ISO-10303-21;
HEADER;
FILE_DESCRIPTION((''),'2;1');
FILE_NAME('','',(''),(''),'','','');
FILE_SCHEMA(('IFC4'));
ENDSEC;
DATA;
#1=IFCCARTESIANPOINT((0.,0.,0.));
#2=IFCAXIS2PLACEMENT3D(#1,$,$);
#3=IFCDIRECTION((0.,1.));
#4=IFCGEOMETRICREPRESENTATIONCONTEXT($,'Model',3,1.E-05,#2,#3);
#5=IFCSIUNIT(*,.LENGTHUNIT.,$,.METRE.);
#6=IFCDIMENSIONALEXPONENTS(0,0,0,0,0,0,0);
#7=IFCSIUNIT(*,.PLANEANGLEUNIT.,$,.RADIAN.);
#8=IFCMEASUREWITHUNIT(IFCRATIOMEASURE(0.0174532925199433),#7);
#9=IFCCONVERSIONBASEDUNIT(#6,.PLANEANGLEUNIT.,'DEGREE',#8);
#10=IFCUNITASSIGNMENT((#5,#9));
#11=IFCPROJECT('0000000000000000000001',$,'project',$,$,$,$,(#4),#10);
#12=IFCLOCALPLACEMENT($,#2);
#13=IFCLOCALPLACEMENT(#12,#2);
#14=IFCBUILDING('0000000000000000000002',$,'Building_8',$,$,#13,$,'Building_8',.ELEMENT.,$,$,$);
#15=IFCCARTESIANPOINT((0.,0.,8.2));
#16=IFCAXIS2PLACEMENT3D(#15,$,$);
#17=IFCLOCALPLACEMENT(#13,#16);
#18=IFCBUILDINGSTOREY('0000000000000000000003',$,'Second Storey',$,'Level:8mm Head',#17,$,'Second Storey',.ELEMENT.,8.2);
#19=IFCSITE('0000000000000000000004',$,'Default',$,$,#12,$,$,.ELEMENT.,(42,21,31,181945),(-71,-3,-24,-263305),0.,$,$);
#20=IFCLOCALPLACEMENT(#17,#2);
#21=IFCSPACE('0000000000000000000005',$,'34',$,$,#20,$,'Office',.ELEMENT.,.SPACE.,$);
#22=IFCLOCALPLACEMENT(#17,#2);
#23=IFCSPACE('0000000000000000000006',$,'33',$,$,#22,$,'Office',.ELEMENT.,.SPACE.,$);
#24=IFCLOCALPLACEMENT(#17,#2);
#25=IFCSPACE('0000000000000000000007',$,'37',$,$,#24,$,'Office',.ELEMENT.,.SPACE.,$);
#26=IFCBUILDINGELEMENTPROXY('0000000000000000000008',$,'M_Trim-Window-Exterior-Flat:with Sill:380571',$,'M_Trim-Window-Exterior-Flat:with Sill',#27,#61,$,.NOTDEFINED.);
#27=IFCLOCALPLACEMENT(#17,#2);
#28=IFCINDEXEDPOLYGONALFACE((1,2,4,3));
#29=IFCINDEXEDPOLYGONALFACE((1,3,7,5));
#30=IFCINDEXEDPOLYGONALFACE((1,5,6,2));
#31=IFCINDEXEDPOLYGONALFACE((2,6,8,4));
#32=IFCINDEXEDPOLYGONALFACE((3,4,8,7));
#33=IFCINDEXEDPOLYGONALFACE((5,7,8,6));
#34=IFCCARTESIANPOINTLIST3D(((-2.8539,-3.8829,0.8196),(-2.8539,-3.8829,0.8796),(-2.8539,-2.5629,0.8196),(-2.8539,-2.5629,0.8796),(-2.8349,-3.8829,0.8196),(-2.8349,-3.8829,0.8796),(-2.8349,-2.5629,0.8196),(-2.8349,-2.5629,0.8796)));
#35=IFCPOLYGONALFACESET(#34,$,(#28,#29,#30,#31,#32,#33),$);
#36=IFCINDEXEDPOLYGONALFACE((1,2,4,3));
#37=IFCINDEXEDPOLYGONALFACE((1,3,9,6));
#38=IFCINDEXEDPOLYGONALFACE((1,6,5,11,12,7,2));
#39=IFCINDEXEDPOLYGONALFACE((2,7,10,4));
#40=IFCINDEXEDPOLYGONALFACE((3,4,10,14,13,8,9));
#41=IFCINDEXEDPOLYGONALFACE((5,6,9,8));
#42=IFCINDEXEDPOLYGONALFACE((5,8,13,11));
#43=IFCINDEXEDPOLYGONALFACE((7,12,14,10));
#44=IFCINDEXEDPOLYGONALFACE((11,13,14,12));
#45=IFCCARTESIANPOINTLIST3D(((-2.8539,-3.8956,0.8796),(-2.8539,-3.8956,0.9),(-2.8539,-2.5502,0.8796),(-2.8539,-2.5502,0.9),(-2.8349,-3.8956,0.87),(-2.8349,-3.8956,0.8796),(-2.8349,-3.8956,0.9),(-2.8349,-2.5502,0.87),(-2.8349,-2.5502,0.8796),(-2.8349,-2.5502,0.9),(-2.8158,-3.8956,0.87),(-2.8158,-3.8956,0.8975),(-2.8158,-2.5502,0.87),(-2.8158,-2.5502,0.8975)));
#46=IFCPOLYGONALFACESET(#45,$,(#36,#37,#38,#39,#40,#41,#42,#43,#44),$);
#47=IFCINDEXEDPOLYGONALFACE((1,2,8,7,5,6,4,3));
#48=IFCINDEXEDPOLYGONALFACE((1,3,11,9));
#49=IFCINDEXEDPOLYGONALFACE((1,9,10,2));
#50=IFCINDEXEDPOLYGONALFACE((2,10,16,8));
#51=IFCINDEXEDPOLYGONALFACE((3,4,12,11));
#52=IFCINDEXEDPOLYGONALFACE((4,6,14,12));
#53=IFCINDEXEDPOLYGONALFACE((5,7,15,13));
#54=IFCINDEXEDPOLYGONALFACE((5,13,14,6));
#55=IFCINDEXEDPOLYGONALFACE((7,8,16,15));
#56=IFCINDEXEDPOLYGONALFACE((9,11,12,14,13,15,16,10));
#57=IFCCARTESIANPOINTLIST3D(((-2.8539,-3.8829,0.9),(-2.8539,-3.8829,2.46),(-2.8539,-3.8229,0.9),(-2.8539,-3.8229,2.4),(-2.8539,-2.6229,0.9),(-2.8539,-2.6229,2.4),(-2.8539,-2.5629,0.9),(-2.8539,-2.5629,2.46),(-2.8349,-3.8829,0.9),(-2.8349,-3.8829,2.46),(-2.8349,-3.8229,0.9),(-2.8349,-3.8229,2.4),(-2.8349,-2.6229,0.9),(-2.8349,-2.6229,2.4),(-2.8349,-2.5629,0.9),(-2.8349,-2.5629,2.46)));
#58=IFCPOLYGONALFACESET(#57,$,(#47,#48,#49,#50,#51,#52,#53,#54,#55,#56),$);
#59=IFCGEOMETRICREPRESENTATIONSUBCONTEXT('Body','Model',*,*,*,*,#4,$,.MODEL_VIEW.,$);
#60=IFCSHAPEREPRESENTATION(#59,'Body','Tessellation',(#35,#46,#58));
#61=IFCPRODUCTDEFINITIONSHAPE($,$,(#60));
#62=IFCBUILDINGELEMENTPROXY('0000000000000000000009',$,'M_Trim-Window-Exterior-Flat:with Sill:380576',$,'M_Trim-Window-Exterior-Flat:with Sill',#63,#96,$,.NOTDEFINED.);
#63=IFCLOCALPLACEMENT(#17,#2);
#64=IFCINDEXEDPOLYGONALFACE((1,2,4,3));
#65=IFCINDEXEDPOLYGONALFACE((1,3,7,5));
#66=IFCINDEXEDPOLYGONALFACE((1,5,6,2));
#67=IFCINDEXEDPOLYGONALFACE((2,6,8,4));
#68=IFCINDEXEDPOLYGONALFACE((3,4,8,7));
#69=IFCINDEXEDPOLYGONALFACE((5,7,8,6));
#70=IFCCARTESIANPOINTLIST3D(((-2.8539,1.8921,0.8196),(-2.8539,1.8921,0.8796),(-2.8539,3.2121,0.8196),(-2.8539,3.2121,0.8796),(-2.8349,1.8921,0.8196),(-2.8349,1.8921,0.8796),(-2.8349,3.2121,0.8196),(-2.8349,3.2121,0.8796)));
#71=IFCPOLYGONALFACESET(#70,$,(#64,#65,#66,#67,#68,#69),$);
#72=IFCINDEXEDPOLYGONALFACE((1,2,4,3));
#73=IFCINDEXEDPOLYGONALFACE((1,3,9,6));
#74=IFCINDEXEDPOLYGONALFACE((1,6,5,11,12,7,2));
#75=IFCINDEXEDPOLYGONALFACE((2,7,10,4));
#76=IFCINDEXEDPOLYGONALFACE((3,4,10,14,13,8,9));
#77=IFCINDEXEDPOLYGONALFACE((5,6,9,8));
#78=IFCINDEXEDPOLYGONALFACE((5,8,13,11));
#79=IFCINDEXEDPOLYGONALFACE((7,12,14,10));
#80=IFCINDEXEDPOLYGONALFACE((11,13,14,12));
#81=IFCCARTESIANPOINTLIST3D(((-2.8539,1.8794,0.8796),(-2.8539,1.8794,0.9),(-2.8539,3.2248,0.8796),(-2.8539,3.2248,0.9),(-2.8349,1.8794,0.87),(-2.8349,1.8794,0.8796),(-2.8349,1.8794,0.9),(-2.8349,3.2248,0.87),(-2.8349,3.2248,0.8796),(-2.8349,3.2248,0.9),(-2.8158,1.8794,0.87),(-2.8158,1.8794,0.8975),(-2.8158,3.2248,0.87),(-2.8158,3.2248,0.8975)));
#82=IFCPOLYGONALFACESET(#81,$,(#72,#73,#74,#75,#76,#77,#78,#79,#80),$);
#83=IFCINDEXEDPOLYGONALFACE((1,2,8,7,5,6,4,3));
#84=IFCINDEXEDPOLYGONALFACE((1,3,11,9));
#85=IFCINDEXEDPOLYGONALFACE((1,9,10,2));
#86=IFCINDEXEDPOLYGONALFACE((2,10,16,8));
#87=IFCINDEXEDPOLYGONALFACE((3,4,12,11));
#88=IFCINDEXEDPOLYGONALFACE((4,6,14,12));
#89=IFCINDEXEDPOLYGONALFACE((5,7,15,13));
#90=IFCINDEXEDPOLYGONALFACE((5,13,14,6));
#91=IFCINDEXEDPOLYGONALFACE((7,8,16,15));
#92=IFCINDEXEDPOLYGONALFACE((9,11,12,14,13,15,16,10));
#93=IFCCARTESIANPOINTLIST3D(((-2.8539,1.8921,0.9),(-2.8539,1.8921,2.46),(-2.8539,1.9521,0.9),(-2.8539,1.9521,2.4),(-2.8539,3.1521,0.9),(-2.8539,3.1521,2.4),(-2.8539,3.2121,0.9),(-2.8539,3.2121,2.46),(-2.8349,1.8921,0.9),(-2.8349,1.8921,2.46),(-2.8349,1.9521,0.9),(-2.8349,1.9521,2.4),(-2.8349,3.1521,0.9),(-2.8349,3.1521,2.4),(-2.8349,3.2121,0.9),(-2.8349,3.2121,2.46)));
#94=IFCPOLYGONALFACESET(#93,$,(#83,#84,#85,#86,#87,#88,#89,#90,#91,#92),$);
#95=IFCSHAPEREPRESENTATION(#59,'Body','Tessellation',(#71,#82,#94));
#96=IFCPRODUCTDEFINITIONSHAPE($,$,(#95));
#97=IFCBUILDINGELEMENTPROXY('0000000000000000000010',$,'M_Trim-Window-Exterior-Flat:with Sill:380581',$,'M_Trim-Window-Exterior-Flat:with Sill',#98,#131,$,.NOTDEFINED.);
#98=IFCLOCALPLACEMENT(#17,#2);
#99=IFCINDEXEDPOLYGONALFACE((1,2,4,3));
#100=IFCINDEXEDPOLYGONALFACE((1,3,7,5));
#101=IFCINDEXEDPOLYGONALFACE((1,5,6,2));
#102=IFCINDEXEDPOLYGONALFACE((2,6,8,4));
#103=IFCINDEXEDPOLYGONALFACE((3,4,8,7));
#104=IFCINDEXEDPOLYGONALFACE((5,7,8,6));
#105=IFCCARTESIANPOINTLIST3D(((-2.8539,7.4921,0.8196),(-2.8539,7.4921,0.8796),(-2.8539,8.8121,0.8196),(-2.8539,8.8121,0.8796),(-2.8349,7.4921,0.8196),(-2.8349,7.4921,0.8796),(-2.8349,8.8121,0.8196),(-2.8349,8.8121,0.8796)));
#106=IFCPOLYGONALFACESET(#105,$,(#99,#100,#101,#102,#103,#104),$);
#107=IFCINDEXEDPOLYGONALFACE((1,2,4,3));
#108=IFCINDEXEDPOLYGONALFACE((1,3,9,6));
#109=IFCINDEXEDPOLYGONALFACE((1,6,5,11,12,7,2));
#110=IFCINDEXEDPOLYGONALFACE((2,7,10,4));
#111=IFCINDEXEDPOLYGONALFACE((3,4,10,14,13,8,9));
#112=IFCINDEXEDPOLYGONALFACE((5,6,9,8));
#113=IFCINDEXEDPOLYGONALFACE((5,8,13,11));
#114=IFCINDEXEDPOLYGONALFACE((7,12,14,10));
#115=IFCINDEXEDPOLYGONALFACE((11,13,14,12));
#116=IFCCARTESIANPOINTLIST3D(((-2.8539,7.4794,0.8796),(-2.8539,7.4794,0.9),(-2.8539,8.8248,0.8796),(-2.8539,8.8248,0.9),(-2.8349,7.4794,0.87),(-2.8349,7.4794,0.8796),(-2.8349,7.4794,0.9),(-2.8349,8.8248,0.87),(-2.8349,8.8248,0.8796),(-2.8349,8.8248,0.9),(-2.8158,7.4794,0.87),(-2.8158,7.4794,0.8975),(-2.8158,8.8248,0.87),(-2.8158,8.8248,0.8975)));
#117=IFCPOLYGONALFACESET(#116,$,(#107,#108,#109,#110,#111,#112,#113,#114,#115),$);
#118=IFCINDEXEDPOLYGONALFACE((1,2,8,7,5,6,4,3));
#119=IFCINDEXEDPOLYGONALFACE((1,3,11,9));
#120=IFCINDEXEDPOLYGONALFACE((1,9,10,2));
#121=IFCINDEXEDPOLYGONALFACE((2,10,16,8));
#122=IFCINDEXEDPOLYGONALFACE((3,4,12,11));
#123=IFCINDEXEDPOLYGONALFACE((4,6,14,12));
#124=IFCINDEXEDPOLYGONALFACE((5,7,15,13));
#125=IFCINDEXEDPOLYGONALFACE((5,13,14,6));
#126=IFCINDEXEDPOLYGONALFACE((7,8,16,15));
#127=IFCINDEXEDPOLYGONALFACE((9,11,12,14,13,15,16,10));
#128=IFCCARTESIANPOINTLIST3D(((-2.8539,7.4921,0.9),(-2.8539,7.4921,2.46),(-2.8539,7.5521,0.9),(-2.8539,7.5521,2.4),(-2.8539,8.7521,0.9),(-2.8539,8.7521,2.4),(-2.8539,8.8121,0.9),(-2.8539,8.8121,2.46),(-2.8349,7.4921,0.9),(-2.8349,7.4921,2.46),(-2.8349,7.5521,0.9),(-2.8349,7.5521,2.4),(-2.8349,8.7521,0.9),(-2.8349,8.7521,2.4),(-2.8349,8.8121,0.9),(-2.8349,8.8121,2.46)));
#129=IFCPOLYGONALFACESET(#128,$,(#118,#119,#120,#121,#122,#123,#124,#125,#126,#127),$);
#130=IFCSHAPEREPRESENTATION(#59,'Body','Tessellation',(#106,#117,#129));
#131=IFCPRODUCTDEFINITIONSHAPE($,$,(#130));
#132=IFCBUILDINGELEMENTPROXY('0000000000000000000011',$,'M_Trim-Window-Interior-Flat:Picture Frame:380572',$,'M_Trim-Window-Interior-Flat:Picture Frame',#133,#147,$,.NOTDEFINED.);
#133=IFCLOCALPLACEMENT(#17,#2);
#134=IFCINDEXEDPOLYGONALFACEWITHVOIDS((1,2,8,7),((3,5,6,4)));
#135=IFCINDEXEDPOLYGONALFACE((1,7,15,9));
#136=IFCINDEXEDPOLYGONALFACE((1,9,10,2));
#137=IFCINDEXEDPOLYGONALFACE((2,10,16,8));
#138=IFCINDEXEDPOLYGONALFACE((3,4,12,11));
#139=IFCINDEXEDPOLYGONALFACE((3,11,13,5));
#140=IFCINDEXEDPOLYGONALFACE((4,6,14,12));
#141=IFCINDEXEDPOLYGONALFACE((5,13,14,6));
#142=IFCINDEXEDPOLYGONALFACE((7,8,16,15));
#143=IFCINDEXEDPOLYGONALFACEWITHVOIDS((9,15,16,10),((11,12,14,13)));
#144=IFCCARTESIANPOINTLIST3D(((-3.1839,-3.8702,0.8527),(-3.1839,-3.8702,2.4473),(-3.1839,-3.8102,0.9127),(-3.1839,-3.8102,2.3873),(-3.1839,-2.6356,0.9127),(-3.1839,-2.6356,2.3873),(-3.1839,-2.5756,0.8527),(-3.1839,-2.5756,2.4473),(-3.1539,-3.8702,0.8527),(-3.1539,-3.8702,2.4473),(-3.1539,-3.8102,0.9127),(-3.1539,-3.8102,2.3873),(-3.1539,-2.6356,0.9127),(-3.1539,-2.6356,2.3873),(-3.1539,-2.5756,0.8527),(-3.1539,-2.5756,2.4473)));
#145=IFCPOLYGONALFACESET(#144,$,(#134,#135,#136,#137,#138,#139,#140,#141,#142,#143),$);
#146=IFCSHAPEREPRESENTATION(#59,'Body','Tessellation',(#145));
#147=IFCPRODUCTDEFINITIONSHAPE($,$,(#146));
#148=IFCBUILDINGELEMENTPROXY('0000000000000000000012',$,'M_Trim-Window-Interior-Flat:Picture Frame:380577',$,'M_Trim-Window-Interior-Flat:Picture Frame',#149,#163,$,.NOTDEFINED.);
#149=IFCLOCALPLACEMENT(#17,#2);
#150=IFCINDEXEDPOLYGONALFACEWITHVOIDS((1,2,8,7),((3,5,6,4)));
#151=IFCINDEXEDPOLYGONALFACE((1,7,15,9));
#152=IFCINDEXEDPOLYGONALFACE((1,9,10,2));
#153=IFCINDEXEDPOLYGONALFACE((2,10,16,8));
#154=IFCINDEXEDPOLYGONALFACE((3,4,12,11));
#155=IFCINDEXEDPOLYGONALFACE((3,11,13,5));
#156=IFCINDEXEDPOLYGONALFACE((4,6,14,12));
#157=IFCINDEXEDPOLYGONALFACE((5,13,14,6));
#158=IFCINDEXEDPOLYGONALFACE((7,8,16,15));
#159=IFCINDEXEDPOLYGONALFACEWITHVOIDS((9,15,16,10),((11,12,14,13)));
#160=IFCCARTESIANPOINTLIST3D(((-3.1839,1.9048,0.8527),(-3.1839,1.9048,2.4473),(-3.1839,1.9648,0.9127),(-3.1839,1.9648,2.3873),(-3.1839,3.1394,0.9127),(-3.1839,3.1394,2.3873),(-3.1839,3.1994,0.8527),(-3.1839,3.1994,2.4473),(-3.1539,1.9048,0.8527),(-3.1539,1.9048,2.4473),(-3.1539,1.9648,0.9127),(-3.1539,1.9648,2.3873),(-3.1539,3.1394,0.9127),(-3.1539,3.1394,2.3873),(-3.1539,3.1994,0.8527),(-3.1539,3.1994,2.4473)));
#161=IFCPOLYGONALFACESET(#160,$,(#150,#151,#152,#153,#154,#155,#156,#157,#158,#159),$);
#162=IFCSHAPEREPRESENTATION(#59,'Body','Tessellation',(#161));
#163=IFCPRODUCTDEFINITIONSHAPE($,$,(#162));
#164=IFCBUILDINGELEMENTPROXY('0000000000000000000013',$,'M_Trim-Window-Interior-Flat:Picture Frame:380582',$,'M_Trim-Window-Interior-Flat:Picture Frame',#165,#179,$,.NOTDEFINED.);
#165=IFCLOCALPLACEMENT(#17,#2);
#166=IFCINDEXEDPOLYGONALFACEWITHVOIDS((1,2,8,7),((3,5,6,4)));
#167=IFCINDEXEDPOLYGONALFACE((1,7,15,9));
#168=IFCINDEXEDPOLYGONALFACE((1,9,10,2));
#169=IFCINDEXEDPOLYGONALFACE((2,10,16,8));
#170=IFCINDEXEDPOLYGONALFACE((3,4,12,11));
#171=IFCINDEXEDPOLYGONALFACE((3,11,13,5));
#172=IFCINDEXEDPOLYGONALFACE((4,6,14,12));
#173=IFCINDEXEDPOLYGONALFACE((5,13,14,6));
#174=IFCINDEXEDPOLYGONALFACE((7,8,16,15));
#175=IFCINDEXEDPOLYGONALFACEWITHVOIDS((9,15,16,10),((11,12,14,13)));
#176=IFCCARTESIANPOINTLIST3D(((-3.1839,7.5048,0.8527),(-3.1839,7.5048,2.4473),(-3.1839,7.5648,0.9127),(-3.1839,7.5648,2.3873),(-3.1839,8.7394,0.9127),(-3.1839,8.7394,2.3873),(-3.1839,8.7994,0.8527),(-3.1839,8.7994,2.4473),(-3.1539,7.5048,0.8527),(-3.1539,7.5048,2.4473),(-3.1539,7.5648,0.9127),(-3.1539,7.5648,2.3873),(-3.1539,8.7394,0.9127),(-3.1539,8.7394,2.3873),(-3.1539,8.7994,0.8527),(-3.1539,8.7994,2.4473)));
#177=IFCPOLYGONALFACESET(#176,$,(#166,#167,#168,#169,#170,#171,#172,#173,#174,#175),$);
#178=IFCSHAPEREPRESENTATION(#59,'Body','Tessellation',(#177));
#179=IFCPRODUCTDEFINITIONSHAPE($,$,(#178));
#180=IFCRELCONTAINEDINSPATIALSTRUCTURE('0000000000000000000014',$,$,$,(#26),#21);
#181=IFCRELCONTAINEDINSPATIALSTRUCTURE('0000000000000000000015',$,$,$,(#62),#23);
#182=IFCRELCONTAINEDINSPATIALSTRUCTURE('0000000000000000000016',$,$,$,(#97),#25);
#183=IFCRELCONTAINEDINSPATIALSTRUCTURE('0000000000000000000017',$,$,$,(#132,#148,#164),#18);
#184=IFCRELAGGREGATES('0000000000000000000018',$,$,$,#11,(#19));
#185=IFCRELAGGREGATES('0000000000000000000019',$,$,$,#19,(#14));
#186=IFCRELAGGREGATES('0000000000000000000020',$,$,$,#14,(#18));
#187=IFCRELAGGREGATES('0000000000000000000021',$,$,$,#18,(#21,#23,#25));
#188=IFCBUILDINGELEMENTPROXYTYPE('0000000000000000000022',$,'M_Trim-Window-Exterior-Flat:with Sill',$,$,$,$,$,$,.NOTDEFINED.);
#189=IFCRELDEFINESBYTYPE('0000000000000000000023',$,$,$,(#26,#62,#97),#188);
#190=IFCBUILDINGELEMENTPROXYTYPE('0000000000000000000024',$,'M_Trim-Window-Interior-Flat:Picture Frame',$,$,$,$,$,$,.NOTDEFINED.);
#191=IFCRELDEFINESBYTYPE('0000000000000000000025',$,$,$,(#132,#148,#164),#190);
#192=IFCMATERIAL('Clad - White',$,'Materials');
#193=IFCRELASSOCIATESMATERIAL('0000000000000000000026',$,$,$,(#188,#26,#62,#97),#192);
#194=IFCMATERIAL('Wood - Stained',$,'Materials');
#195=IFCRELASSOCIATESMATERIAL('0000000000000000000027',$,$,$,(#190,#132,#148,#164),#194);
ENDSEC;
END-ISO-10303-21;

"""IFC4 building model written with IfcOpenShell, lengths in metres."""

from ifc_helpers import new_model, entity, si_unit, converted_unit, direction, frame, origin, place, context, subcontext, project, spatial, indexed_curve, outline, extrude, source, transform, mapped, material, type_object, type_shapes, element, save


model = new_model("IFC4")

# Units and contexts
model_context = context("Model", 3, precision=1e-05, world=origin(), true_north=direction((0.0, 1.0)))
body_context = subcontext(model_context, "Body", "Model", "MODEL_VIEW")
ifc_project = project(units=[si_unit("LENGTHUNIT", "METRE"), converted_unit("PLANEANGLEUNIT", "DEGREE", entity("IfcRatioMeasure", 0.0174532925199433), si_unit("PLANEANGLEUNIT", "RADIAN"), dimensions=[0, 0, 0, 0, 0, 0, 0])], contexts=[model_context])

# Site, building, storey
site_placement = place(None, origin())
site = spatial("IfcSite", under=ifc_project, at=site_placement, Name="Default", CompositionType="ELEMENT", RefLatitude=(42, 21, 31, 181945), RefLongitude=(-71, -3, -24, -263305), RefElevation=0.0)
building_placement = place(site_placement, origin())
building = spatial("IfcBuilding", under=site, at=building_placement, Name="Building_8", LongName="Building_8", CompositionType="ELEMENT")
storey_placement = place(building_placement, frame((0.0, 0.0, 8.2)))
storey = spatial("IfcBuildingStorey", under=building, at=storey_placement, Name="Second Storey", ObjectType="Level:8mm Head", LongName="Second Storey", CompositionType="ELEMENT", Elevation=8.2)

# Shared definitions
ifc_material_1 = material(Name="Clad - White", Category="Materials")
ifc_material_2 = material(Name="Wood - Stained", Category="Materials")

# Shared definitions
space_1_placement = place(storey_placement, origin())
space_1 = spatial("IfcSpace", under=storey, at=space_1_placement, Name="34", LongName="Office", CompositionType="ELEMENT", PredefinedType="SPACE")

# Building element proxy
building_element_proxy_type_1 = type_object("IfcBuildingElementProxyType", Name="M_Trim-Window-Exterior-Flat:with Sill", PredefinedType="NOTDEFINED", material=ifc_material_1)
shared_shape_1 = source(origin(), body_context, "Body", "SweptSolid", [
    extrude(outline(indexed_curve([(-0.03, -0.66), (0.03, -0.66), (0.03, 0.66), (-0.03, 0.66), (-0.03, -0.66)], self_intersect=False)), frame((0.0, 1.5504, 0.0), z_axis=(0.0, 0.0, 1.0), x_axis=(0.0, 1.0, 0.0)), (0.0, 0.0, 1.0), 0.0191),
    extrude(outline(indexed_curve([(-0.0152, -0.019), (0.0123, -0.019), (0.0148, 0.0), (0.0148, 0.019), (-0.0057, 0.019), (-0.0057, 0.0), (-0.0152, 0.0), (-0.0152, -0.019)], self_intersect=False)), frame((-0.6727, 1.5148, 0.019), z_axis=(1.0, 0.0, 0.0), x_axis=(0.0, -1.0, 0.0)), (0.0, 0.0, 1.0), 1.3454),
    extrude(outline(indexed_curve([(-0.66, -0.795), (0.66, -0.795), (0.66, 0.765), (0.6, 0.765), (0.6, -0.735), (-0.6, -0.735), (-0.6, 0.765), (-0.66, 0.765), (-0.66, -0.795)], self_intersect=False)), frame((0.0, 0.735, 0.0)), (0.0, 0.0, 1.0), 0.0191),
])
type_shapes(building_element_proxy_type_1, [shared_shape_1])
proxy_1_placement = place(space_1_placement, frame((-2.8539, -3.2229, 2.4), z_axis=(1.0, 0.0, 0.0), x_axis=(0.0, -1.0, 0.0)))
element("IfcBuildingElementProxy", 1, at=proxy_1_placement, inside=space_1, type_object=building_element_proxy_type_1, material=ifc_material_1, Name="M_Trim-Window-Exterior-Flat:with Sill:380571", ObjectType="M_Trim-Window-Exterior-Flat:with Sill", PredefinedType="NOTDEFINED", context=body_context, shape_type="MappedRepresentation", body=[
    mapped(shared_shape_1, transform((0.0, 0.0, 0.0), scale=1.0)),
])

# Shared definitions
space_2_placement = place(storey_placement, origin())
space_2 = spatial("IfcSpace", under=storey, at=space_2_placement, Name="33", LongName="Office", CompositionType="ELEMENT", PredefinedType="SPACE")

# Building element proxy
proxy_2_placement = place(space_2_placement, frame((-2.8539, 2.5521, 2.4), z_axis=(1.0, 0.0, 0.0), x_axis=(0.0, -1.0, 0.0)))
element("IfcBuildingElementProxy", 2, at=proxy_2_placement, inside=space_2, type_object=building_element_proxy_type_1, material=ifc_material_1, Name="M_Trim-Window-Exterior-Flat:with Sill:380576", ObjectType="M_Trim-Window-Exterior-Flat:with Sill", PredefinedType="NOTDEFINED", context=body_context, shape_type="MappedRepresentation", body=[
    mapped(shared_shape_1, transform((0.0, 0.0, 0.0), scale=1.0)),
])

# Shared definitions
space_3_placement = place(storey_placement, origin())
space_3 = spatial("IfcSpace", under=storey, at=space_3_placement, Name="37", LongName="Office", CompositionType="ELEMENT", PredefinedType="SPACE")

# Building element proxies
proxy_3_placement = place(space_3_placement, frame((-2.8539, 8.1521, 2.4), z_axis=(1.0, 0.0, 0.0), x_axis=(0.0, -1.0, 0.0)))
element("IfcBuildingElementProxy", 3, at=proxy_3_placement, inside=space_3, type_object=building_element_proxy_type_1, material=ifc_material_1, Name="M_Trim-Window-Exterior-Flat:with Sill:380581", ObjectType="M_Trim-Window-Exterior-Flat:with Sill", PredefinedType="NOTDEFINED", context=body_context, shape_type="MappedRepresentation", body=[
    mapped(shared_shape_1, transform((0.0, 0.0, 0.0), scale=1.0)),
])
building_element_proxy_type_2 = type_object("IfcBuildingElementProxyType", Name="M_Trim-Window-Interior-Flat:Picture Frame", PredefinedType="NOTDEFINED", material=ifc_material_2)
shared_shape_2 = source(origin(), body_context, "Body", "SweptSolid", [
    extrude(outline(indexed_curve([(-0.7973, -0.6473), (0.7973, -0.6473), (0.7973, 0.6473), (-0.7973, 0.6473), (-0.7973, -0.6473)], self_intersect=False), holes=[indexed_curve([(-0.7373, -0.5873), (-0.7373, 0.5873), (0.7373, 0.5873), (0.7373, -0.5873), (-0.7373, -0.5873)], self_intersect=False)]), frame((0.0, 0.75, 0.0), z_axis=(0.0, 0.0, 1.0), x_axis=(0.0, 1.0, 0.0)), (0.0, 0.0, 1.0), 0.03),
])
type_shapes(building_element_proxy_type_2, [shared_shape_2])
for number, where, z_axis, x_axis, name in (
    (4, (-3.1539, -3.2229, 2.4), (-1.0, 0.0, 0.0), (0.0, 1.0, 0.0), "M_Trim-Window-Interior-Flat:Picture Frame:380572"),
    (5, (-3.1539, 2.5521, 2.4), (-1.0, 0.0, 0.0), (0.0, 1.0, 0.0), "M_Trim-Window-Interior-Flat:Picture Frame:380577"),
    (6, (-3.1539, 8.1521, 2.4), (-1.0, 0.0, 0.0), (0.0, 1.0, 0.0), "M_Trim-Window-Interior-Flat:Picture Frame:380582"),
):
    element("IfcBuildingElementProxy", number, at=place(storey_placement, frame(where, z_axis=z_axis, x_axis=x_axis)), inside=storey, type_object=building_element_proxy_type_2, material=ifc_material_2, Name=name, ObjectType="M_Trim-Window-Interior-Flat:Picture Frame", PredefinedType="NOTDEFINED", context=body_context, shape_type="MappedRepresentation", body=[
        mapped(shared_shape_2, transform((0.0, 0.0, 0.0), scale=1.0)),
    ])

save(model, "model.ifc")
